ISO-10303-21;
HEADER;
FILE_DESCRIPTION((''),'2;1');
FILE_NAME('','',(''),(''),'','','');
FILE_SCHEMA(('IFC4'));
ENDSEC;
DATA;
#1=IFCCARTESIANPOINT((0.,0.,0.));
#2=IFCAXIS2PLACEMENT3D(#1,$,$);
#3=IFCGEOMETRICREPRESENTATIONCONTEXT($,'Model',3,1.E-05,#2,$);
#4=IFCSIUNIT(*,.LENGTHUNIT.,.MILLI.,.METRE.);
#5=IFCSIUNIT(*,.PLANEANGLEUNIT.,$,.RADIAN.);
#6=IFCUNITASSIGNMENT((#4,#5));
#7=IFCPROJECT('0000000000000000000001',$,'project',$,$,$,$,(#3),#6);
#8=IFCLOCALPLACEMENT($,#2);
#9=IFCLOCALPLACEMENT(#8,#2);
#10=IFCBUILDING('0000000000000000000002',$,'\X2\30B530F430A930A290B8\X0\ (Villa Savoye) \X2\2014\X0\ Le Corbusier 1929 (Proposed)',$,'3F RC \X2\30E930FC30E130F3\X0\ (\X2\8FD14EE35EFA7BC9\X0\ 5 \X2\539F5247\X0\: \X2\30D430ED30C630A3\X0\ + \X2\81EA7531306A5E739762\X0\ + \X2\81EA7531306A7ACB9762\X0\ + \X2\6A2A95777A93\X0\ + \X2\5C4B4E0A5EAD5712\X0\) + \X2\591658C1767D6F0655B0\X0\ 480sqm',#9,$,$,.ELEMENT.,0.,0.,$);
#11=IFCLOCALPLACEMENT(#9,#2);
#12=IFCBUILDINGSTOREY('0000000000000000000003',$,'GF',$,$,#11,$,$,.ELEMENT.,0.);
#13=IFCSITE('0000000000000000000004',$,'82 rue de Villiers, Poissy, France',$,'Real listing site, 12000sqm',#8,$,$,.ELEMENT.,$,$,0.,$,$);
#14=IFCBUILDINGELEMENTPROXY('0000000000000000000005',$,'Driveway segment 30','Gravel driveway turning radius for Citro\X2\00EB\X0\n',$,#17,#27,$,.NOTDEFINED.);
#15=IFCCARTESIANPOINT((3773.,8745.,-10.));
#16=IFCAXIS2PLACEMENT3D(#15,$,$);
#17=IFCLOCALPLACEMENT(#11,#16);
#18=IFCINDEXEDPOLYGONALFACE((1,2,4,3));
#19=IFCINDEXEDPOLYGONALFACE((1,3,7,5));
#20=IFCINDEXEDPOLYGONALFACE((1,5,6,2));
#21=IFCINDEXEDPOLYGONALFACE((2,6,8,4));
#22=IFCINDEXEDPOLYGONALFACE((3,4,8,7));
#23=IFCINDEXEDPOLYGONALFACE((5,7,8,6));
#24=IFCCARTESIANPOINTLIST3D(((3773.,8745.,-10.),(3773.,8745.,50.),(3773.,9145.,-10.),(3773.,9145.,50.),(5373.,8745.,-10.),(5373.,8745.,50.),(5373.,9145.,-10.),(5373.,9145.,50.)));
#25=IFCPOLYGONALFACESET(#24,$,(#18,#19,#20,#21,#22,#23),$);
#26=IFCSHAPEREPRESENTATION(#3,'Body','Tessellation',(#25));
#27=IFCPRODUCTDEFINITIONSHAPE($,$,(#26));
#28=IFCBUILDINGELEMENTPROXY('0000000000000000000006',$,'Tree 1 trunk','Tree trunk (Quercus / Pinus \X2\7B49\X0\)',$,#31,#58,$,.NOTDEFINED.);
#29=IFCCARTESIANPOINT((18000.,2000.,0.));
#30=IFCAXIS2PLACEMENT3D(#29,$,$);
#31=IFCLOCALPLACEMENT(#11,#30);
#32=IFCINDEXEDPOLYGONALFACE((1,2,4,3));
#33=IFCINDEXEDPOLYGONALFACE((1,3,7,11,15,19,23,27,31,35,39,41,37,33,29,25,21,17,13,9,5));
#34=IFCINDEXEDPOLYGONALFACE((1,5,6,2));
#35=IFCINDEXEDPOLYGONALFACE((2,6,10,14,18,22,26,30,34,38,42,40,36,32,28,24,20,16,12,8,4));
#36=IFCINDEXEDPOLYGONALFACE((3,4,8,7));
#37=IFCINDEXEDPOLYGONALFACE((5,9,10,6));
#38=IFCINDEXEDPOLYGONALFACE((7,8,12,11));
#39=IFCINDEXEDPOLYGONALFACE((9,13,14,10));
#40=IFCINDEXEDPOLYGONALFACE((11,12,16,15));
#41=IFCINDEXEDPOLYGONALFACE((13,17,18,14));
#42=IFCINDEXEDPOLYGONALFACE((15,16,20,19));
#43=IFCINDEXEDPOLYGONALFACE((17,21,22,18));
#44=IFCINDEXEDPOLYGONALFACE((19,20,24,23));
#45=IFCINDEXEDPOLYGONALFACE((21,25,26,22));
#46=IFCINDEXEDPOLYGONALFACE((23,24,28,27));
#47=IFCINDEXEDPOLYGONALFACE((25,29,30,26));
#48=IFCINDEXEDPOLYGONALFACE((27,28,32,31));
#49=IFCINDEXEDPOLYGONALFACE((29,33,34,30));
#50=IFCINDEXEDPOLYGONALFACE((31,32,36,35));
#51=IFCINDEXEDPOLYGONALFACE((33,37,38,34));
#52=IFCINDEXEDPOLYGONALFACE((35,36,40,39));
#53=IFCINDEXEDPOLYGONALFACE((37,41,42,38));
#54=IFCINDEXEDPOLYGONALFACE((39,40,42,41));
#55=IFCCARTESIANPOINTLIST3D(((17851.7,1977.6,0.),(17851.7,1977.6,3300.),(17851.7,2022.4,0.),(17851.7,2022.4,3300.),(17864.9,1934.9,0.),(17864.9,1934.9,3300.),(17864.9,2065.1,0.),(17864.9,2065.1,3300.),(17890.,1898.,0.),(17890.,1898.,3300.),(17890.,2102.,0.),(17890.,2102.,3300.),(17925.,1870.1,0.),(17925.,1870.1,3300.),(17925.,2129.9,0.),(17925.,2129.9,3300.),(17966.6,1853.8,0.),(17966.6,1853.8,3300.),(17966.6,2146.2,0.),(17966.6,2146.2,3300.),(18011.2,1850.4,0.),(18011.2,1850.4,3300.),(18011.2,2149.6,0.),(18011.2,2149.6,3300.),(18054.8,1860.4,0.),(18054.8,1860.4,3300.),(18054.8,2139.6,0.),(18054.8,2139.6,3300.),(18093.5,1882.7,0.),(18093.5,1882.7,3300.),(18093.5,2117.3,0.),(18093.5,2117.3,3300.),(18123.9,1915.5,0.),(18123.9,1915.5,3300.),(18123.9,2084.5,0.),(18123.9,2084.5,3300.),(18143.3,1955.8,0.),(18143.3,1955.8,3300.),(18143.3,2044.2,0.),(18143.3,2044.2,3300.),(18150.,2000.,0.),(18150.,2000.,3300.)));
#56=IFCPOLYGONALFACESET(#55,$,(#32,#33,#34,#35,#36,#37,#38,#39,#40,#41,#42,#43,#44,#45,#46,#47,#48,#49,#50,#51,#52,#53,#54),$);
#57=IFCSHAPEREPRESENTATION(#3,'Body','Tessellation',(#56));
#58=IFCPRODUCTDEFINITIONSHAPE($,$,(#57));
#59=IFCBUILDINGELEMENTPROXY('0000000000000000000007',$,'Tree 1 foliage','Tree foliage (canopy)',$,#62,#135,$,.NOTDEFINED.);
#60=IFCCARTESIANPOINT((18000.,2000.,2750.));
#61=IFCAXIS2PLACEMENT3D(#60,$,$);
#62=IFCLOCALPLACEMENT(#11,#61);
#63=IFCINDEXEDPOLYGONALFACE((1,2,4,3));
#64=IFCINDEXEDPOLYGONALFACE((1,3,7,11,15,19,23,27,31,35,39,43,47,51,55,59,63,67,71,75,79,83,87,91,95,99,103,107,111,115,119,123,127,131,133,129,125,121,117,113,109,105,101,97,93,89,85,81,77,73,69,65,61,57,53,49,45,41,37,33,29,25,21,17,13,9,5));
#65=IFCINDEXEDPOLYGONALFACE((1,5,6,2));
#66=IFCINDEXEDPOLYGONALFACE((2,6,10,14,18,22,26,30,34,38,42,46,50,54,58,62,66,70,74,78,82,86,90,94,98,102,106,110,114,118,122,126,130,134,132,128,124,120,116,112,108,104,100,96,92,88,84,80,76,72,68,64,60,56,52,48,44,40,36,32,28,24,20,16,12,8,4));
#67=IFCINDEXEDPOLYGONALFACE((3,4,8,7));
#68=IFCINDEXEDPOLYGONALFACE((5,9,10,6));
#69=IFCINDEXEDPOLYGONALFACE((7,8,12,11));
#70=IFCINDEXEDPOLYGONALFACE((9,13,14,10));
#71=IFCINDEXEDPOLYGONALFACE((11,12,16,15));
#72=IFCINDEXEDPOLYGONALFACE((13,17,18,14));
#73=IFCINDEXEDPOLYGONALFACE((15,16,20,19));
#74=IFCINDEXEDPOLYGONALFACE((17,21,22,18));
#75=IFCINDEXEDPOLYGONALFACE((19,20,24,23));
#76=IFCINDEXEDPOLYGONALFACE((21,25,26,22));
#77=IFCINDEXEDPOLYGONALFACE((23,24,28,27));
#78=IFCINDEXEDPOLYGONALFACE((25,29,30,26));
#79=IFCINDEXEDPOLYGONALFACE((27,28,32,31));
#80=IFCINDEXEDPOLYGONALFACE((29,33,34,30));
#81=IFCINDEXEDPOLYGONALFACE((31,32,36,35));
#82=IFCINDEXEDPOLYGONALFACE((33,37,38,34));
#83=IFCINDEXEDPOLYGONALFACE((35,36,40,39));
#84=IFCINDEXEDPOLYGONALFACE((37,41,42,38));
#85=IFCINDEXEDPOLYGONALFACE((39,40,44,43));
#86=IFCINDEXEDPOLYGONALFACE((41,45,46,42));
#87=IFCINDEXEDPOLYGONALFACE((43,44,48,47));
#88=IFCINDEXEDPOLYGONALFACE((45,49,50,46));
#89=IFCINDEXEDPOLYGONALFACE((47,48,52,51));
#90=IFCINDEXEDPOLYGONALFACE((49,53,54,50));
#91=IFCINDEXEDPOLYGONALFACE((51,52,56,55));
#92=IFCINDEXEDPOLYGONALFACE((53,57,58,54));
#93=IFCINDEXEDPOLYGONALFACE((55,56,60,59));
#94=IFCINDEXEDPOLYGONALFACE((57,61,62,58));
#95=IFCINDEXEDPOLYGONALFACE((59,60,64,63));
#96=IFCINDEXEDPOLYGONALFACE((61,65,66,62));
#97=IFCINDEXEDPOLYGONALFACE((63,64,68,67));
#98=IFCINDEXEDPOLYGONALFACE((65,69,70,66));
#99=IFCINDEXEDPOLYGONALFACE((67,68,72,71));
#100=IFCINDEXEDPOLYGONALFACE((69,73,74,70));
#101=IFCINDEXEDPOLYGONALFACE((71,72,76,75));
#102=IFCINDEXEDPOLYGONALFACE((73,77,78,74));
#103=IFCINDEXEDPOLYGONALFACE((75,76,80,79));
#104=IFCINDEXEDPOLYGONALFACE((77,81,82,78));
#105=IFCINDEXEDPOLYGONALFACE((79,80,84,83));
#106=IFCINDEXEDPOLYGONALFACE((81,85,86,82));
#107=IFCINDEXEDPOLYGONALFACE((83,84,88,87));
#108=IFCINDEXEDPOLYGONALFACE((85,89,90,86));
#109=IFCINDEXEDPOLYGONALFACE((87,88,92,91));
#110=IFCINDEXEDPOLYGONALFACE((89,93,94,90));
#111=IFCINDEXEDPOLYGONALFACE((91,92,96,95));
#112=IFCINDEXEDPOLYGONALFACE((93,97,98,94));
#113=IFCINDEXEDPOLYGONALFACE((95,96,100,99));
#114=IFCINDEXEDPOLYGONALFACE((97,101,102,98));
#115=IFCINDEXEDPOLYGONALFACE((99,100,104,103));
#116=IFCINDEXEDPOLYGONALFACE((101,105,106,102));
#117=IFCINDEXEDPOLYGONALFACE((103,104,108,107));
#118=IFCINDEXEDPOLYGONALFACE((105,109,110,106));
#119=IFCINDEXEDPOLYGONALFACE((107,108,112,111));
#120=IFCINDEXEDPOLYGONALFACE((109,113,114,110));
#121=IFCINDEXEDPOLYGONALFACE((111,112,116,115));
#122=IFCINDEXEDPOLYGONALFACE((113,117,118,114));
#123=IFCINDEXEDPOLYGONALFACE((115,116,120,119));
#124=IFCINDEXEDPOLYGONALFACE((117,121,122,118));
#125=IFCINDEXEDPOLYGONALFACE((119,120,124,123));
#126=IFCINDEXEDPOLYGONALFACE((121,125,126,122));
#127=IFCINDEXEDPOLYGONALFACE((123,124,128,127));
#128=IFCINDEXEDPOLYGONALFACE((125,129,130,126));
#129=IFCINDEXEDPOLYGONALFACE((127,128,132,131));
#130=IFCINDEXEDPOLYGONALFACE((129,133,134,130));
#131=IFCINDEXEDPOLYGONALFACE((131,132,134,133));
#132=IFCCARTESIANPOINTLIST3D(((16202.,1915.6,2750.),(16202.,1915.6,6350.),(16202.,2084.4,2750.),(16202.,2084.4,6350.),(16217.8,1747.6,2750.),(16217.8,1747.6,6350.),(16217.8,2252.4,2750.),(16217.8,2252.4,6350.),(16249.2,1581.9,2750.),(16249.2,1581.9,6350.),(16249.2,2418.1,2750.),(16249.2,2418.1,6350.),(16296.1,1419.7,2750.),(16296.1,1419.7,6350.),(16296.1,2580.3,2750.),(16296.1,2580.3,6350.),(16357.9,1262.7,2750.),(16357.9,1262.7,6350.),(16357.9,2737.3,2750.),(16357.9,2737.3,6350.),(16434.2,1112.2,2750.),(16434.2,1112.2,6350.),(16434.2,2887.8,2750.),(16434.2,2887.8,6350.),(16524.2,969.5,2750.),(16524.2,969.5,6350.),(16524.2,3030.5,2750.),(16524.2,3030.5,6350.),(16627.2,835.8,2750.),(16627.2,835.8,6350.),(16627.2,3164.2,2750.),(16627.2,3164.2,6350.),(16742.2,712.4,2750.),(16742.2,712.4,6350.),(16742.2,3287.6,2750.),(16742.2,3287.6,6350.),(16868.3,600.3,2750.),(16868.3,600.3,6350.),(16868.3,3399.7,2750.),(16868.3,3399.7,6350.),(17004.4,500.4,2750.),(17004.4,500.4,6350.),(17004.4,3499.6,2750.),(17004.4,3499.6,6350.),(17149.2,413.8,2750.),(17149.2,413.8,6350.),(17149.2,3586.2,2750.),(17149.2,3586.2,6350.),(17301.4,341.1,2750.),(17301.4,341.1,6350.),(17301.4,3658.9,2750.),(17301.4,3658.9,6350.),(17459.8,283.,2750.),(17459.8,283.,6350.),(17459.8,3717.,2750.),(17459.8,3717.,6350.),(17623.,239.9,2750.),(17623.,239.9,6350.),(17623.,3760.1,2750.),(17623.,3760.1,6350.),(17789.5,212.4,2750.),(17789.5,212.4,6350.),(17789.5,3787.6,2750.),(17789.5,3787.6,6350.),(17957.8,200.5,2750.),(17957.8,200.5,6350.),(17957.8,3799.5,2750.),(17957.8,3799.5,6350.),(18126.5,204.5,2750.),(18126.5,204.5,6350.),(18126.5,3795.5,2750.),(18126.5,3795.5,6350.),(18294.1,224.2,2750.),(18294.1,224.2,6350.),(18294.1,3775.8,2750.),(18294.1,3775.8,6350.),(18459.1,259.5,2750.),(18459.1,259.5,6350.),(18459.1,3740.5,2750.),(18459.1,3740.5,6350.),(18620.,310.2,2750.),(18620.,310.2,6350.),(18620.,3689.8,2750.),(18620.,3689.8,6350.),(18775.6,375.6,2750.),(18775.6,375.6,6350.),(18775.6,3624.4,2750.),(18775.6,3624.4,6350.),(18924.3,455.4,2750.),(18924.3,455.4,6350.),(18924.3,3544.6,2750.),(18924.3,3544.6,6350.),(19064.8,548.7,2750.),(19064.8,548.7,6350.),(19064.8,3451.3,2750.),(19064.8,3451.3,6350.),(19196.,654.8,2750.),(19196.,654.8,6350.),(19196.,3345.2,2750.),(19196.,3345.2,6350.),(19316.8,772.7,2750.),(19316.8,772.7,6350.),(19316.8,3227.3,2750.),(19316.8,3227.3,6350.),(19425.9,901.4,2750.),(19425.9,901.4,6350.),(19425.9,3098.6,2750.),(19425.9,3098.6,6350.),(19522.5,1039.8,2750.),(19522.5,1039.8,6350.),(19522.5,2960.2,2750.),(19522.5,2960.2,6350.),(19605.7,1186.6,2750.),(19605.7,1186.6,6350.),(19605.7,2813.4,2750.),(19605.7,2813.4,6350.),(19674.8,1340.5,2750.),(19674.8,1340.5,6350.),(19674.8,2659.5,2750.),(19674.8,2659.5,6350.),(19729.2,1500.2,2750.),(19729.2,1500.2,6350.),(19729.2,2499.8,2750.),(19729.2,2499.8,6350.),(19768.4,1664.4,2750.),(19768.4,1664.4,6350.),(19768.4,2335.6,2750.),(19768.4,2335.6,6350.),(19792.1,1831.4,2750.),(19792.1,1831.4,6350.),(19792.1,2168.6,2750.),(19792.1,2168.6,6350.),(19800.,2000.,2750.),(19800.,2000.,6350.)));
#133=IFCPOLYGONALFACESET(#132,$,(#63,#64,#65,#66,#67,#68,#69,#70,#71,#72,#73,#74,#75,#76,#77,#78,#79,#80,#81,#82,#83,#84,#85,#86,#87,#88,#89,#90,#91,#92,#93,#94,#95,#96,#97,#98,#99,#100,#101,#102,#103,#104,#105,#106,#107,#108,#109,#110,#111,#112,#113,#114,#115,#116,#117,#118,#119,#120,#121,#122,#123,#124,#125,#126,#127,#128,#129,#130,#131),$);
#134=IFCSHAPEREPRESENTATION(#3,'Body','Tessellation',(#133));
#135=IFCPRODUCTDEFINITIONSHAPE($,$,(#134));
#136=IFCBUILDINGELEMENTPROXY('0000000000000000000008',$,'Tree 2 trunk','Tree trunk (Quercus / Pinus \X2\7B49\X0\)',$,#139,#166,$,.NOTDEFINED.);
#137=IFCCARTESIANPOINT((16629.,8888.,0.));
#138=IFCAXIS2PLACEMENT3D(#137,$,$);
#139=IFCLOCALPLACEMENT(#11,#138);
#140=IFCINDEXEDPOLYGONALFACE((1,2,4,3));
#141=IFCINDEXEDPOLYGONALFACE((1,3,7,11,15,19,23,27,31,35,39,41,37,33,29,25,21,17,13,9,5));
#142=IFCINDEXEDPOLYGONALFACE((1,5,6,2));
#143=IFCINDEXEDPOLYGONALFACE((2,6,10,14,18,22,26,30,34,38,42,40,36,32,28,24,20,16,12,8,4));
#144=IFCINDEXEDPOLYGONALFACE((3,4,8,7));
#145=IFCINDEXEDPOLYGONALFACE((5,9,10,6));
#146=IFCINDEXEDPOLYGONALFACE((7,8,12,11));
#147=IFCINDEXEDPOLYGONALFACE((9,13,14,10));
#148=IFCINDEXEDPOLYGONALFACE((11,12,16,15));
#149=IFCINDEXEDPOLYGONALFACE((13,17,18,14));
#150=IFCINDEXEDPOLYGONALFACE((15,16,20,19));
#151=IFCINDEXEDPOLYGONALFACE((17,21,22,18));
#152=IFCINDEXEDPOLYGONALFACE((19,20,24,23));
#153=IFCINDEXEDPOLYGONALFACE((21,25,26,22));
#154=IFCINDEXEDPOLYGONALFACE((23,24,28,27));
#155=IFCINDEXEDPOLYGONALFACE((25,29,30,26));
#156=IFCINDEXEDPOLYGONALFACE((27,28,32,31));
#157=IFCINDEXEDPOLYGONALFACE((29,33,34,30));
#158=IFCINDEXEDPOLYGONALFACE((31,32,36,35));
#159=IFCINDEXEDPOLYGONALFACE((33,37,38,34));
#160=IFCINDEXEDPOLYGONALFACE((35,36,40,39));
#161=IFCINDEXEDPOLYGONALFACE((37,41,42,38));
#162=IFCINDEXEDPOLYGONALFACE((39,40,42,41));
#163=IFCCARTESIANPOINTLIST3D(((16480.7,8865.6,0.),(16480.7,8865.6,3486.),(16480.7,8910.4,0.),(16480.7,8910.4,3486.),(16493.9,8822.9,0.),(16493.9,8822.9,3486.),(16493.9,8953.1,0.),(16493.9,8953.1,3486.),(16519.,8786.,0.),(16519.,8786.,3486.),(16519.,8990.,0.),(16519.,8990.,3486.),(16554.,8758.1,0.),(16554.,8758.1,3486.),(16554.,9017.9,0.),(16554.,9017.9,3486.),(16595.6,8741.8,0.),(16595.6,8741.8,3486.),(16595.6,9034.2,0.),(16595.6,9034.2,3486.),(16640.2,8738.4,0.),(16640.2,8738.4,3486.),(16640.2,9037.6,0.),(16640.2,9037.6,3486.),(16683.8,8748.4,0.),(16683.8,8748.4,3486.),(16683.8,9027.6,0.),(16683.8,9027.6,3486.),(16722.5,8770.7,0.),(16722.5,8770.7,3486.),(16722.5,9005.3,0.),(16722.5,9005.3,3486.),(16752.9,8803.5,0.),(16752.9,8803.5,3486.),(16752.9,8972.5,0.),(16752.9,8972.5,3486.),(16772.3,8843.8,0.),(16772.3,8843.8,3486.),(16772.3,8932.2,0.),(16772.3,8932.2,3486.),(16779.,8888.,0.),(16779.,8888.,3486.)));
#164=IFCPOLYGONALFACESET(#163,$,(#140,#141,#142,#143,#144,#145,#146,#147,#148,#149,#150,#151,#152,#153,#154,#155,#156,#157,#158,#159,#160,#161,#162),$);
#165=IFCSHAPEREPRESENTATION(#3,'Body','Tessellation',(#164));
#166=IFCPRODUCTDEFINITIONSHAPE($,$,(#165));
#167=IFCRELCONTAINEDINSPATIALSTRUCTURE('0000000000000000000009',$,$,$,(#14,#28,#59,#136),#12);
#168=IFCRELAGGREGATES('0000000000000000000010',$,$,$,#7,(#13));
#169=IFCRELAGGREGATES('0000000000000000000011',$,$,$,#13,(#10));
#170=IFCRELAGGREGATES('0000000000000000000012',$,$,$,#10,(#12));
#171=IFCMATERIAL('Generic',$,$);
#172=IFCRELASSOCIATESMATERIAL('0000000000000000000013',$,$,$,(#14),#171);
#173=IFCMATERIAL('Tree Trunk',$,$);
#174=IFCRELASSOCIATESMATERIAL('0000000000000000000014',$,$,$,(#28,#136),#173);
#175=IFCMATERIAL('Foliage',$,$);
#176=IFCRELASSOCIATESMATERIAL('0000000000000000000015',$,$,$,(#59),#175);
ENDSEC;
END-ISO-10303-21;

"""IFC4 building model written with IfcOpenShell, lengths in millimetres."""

from ifc_helpers import new_model, si_unit, frame, frame_2d, origin, origin_2d, place, context, project, spatial, rectangle, circle, extrude, material, element, save


model = new_model("IFC4")

# Units and contexts
model_context = context("Model", 3, precision=1e-05, world=origin())
ifc_project = project(units=[si_unit("LENGTHUNIT", "METRE", prefix="MILLI"), si_unit("PLANEANGLEUNIT", "RADIAN")], contexts=[model_context])

# Site, building, storey
site_placement = place(None, origin())
site = spatial("IfcSite", under=ifc_project, at=site_placement, Name="82 rue de Villiers, Poissy, France", ObjectType="Real listing site, 12000sqm", CompositionType="ELEMENT", RefElevation=0.0)
building_placement = place(site_placement, origin())
building = spatial("IfcBuilding", under=site, at=building_placement, Name="サヴォア邸 (Villa Savoye) — Le Corbusier 1929 (Proposed)", ObjectType="3F RC ラーメン (近代建築 5 原則: ピロティ + 自由な平面 + 自由な立面 + 横長窓 + 屋上庭園) + 外壁白漆喰 480sqm", CompositionType="ELEMENT", ElevationOfRefHeight=0.0, ElevationOfTerrain=0.0)
storey_placement = place(building_placement, origin())
storey = spatial("IfcBuildingStorey", under=building, at=storey_placement, Name="GF", CompositionType="ELEMENT", Elevation=0.0)

# Shared definitions
ifc_material_1 = material(Name="Generic")

# Building element proxies
proxy_1_placement = place(storey_placement, frame((3773.0, 8745.0, -10.0)))
element("IfcBuildingElementProxy", 1, at=proxy_1_placement, inside=storey, material=ifc_material_1, Name="Driveway segment 30", Description="Gravel driveway turning radius for Citroën", PredefinedType="NOTDEFINED", context=model_context, shape_type="SweptSolid", body=[
    extrude(rectangle(XDim=1600.0, YDim=400.0, at=frame_2d((800.0, 200.0))), frame((3773.0, 8745.0, -10.0)), (0.0, 0.0, 1.0), 60.0),
])
ifc_material_2 = material(Name="Tree Trunk")
proxy_2_placement = place(storey_placement, frame((18000.0, 2000.0, 0.0)))
element("IfcBuildingElementProxy", 2, at=proxy_2_placement, inside=storey, material=ifc_material_2, Name="Tree 1 trunk", Description="Tree trunk (Quercus / Pinus 等)", PredefinedType="NOTDEFINED", context=model_context, shape_type="SweptSolid", body=[
    extrude(circle(Radius=150.0, at=origin_2d()), frame((18000.0, 2000.0, 0.0)), (0.0, 0.0, 1.0), 3300.0),
])
ifc_material_3 = material(Name="Foliage")
proxy_3_placement = place(storey_placement, frame((18000.0, 2000.0, 2750.0)))
element("IfcBuildingElementProxy", 3, at=proxy_3_placement, inside=storey, material=ifc_material_3, Name="Tree 1 foliage", Description="Tree foliage (canopy)", PredefinedType="NOTDEFINED", context=model_context, shape_type="SweptSolid", body=[
    extrude(circle(Radius=1800.0, at=origin_2d()), frame((18000.0, 2000.0, 2750.0)), (0.0, 0.0, 1.0), 3600.0),
])
proxy_4_placement = place(storey_placement, frame((16629.0, 8888.0, 0.0)))
element("IfcBuildingElementProxy", 4, at=proxy_4_placement, inside=storey, material=ifc_material_2, Name="Tree 2 trunk", Description="Tree trunk (Quercus / Pinus 等)", PredefinedType="NOTDEFINED", context=model_context, shape_type="SweptSolid", body=[
    extrude(circle(Radius=150.0, at=origin_2d()), frame((16629.0, 8888.0, 0.0)), (0.0, 0.0, 1.0), 3486.0),
])

save(model, "model.ifc")
